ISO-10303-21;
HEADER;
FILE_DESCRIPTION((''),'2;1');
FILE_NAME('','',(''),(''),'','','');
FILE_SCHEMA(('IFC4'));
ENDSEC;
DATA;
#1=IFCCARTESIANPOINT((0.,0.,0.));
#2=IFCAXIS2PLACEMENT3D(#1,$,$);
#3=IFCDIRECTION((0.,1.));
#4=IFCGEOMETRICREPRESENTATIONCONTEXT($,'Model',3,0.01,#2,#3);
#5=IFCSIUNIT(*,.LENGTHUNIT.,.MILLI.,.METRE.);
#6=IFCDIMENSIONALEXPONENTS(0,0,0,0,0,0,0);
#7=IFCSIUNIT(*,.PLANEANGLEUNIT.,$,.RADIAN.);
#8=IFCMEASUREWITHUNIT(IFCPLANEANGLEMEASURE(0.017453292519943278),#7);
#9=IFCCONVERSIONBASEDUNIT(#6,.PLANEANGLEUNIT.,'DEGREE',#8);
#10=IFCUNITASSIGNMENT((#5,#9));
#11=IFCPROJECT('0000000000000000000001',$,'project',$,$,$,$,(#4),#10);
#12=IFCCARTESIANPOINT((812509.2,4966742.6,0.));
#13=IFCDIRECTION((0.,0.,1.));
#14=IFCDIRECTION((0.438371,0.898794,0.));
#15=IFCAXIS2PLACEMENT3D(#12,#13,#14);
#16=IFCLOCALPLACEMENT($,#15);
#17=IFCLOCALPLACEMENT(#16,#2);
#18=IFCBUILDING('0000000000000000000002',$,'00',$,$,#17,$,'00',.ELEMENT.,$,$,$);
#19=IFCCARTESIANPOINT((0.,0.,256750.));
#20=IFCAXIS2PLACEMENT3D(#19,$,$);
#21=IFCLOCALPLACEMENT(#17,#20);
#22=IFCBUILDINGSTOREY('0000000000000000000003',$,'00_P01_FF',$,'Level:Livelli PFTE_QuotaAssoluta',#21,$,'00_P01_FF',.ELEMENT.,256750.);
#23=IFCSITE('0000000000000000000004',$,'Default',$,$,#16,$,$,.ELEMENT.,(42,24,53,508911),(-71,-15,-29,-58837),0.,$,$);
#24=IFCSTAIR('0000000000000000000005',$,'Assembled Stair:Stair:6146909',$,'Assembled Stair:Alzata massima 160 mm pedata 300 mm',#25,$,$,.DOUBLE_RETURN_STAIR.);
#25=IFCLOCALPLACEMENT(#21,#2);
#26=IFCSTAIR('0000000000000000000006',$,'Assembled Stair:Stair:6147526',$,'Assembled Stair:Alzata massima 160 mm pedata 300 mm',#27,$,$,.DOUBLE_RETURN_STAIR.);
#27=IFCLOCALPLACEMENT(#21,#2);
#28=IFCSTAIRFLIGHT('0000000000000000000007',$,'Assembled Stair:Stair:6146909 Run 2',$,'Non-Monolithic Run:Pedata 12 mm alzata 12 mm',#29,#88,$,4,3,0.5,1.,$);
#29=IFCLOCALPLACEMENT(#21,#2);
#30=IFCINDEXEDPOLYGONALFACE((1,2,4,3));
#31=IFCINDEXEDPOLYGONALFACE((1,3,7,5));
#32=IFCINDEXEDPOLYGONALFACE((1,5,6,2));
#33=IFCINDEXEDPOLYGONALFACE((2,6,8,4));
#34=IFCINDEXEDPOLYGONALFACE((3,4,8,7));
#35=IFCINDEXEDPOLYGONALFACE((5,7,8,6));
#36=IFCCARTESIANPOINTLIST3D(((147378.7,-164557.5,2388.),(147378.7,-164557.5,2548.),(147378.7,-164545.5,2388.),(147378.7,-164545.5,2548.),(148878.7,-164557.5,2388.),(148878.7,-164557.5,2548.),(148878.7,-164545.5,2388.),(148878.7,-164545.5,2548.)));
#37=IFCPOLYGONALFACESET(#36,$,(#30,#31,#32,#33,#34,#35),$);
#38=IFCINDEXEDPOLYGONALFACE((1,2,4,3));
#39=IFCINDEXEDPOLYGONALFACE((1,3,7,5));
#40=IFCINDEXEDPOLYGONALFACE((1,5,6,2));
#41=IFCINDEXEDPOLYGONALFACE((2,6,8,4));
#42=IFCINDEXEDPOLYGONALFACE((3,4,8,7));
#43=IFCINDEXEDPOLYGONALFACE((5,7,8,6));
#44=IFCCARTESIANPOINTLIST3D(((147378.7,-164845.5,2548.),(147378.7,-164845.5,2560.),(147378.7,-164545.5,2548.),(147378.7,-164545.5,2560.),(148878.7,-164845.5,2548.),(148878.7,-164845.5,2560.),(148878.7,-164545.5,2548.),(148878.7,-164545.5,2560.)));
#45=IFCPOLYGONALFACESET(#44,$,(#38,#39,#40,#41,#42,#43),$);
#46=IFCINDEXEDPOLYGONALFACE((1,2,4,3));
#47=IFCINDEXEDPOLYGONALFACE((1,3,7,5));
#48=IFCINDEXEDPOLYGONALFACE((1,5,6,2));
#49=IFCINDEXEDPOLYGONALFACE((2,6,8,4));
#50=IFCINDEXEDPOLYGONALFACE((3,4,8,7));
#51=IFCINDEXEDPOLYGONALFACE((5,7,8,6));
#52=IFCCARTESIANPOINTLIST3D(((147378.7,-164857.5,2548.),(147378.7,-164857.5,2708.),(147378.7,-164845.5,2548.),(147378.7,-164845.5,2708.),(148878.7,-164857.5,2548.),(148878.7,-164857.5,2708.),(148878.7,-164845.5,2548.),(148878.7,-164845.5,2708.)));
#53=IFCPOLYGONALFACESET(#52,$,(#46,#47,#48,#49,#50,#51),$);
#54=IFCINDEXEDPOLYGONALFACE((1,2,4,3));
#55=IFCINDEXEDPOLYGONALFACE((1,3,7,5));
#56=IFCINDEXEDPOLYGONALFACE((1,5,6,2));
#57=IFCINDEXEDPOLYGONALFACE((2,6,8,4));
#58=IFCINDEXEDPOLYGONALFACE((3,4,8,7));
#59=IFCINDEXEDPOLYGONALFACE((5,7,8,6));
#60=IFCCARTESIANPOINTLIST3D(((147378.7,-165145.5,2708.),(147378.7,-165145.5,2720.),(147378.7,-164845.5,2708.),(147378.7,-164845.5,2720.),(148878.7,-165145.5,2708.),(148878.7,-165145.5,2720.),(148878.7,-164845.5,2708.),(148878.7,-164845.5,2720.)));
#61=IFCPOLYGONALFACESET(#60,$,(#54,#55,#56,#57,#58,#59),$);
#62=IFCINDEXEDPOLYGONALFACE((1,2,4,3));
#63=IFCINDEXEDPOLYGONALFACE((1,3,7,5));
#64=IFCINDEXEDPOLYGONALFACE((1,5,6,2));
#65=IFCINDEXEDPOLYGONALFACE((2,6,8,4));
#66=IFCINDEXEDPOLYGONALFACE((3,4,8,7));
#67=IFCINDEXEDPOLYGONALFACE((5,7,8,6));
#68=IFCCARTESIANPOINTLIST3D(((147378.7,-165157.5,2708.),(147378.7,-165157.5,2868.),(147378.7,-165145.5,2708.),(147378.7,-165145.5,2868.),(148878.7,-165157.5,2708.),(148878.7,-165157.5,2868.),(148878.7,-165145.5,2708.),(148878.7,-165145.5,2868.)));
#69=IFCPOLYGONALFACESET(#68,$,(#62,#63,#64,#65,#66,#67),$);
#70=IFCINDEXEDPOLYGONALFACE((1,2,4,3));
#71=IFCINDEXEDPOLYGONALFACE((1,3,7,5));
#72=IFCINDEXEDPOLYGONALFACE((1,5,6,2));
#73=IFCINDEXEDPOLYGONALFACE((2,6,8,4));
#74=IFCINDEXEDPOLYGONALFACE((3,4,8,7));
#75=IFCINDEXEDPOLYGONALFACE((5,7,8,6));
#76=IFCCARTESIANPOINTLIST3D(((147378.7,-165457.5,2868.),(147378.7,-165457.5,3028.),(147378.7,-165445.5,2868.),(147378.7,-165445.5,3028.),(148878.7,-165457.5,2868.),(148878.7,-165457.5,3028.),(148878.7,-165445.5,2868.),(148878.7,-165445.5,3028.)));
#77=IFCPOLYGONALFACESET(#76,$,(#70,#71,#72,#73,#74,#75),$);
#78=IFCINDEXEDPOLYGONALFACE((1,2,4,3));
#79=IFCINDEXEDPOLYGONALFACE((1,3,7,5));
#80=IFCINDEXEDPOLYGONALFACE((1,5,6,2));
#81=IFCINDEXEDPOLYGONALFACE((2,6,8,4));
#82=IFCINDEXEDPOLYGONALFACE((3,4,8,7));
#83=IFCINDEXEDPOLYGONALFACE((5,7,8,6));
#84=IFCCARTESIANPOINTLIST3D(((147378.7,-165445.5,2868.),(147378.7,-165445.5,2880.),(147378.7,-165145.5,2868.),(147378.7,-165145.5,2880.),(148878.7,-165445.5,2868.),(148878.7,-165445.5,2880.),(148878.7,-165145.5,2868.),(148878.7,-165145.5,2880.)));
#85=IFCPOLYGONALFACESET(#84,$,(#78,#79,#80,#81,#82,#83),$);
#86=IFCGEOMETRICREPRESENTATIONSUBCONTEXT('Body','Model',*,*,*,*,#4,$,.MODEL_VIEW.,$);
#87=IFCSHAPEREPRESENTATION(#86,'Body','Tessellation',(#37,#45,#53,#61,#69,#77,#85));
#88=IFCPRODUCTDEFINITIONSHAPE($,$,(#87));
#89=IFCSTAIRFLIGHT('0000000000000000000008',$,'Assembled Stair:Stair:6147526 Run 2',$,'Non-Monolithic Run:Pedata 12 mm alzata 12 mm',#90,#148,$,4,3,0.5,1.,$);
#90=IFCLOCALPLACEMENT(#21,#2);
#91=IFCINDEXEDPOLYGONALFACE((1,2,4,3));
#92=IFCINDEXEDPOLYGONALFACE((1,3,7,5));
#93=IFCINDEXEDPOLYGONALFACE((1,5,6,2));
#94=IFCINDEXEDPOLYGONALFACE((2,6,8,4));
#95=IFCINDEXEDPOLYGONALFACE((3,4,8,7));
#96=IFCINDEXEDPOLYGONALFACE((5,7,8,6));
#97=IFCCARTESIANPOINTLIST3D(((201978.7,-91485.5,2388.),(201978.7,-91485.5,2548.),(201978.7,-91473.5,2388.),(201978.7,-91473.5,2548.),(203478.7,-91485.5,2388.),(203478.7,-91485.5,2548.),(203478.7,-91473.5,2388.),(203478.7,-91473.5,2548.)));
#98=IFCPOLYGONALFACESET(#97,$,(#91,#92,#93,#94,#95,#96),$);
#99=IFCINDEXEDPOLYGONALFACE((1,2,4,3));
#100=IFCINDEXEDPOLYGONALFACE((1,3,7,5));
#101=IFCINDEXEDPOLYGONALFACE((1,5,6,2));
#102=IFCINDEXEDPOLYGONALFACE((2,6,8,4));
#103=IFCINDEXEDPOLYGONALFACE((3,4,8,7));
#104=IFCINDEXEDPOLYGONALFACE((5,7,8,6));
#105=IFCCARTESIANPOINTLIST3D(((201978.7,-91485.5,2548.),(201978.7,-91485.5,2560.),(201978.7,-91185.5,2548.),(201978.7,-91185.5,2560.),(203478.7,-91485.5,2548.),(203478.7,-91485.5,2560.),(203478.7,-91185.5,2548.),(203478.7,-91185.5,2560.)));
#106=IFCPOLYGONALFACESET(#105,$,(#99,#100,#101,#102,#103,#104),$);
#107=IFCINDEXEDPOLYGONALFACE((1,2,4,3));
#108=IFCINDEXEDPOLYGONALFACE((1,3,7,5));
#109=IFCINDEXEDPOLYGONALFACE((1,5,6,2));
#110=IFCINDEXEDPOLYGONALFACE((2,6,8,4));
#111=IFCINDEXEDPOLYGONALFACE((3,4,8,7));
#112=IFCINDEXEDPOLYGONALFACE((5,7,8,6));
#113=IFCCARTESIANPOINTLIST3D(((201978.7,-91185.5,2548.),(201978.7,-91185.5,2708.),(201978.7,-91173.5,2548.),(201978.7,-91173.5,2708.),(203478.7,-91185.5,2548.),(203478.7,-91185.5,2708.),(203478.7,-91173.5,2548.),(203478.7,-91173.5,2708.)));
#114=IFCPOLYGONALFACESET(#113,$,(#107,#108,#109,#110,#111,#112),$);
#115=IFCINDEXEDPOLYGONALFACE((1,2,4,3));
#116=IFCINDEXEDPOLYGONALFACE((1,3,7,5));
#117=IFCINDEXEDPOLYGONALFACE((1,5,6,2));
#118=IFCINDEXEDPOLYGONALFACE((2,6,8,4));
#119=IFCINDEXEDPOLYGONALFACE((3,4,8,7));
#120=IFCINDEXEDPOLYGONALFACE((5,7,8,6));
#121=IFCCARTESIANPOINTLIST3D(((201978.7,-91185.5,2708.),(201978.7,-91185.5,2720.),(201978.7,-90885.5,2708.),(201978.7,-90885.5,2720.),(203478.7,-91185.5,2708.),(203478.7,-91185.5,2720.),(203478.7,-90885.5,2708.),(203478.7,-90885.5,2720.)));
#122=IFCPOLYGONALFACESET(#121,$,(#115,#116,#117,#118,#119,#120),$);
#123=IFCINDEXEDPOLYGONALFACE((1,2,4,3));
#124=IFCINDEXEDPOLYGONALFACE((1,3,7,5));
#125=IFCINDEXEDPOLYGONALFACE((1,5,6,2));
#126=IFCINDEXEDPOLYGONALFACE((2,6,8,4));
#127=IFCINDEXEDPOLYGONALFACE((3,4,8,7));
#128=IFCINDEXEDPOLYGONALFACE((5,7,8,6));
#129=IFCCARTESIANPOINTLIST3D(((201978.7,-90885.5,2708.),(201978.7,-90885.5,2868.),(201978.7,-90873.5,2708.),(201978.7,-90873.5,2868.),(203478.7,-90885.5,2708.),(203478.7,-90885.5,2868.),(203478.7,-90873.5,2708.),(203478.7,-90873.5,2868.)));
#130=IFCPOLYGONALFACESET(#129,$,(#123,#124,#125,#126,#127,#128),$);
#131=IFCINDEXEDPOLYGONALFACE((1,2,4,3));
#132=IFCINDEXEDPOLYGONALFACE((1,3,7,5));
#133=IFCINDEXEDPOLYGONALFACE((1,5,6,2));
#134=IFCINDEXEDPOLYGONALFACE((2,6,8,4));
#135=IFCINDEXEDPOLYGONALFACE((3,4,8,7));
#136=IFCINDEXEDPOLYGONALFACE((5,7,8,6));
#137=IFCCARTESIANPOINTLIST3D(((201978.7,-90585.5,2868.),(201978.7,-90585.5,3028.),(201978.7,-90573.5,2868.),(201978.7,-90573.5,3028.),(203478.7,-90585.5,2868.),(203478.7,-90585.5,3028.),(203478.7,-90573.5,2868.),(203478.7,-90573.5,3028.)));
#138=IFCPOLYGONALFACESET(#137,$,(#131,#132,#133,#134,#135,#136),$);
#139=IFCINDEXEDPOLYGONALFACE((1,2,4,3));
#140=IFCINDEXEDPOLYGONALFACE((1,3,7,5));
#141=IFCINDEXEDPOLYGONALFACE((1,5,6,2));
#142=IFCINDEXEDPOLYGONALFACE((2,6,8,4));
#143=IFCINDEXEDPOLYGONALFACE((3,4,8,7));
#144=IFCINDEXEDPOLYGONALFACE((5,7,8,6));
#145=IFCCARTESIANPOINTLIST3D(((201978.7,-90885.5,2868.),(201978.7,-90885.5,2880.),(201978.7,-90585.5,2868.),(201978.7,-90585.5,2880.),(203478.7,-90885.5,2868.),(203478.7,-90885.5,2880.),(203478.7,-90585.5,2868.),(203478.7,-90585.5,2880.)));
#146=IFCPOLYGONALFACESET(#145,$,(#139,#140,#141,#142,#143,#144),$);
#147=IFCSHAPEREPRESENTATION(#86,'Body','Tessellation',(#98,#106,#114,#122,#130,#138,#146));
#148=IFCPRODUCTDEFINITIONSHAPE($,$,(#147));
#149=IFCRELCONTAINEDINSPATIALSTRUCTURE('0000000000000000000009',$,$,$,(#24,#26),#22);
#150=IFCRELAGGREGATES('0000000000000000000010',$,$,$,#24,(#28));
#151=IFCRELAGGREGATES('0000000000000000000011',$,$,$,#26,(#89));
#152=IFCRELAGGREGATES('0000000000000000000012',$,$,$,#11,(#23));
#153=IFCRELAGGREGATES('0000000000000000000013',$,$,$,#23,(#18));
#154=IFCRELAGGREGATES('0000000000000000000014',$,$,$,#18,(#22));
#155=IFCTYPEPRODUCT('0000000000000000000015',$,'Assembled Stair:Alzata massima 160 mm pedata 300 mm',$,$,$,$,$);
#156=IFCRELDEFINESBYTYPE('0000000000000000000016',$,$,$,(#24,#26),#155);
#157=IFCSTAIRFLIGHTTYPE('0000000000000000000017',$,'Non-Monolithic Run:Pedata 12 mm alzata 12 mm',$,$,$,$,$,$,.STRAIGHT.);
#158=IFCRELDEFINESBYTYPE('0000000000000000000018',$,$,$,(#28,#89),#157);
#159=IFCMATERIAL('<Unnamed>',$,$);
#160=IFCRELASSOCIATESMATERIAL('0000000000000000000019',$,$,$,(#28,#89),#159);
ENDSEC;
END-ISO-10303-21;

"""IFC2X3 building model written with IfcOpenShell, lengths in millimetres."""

from ifc_helpers import new_model, entity, si_unit, converted_unit, direction, frame, frame_2d, origin, origin_2d_with_axis, place, context, subcontext, project, spatial, rectangle, extrude, material, type_object, element, aggregate, save


model = new_model("IFC2X3")

# Units and contexts
model_context = context("Model", 3, precision=0.01, world=origin(), true_north=direction((0.0, 1.0)))
body_context = subcontext(model_context, "Body", "Model", "MODEL_VIEW")
ifc_project = project(units=[si_unit("LENGTHUNIT", "METRE", prefix="MILLI"), converted_unit("PLANEANGLEUNIT", "DEGREE", entity("IfcPlaneAngleMeasure", 0.017453292519943278), si_unit("PLANEANGLEUNIT", "RADIAN"), dimensions=[0, 0, 0, 0, 0, 0, 0])], contexts=[model_context])

# Site, building, storey
site_placement = place(None, frame((812509.2, 4966742.6, 0.0), z_axis=(0.0, 0.0, 1.0), x_axis=(0.438371, 0.898794, 0.0)))
site = spatial("IfcSite", under=ifc_project, at=site_placement, Name="Default", CompositionType="ELEMENT", RefLatitude=(42, 24, 53, 508911), RefLongitude=(-71, -15, -29, -58837), RefElevation=0.0)
building_placement = place(site_placement, origin())
building = spatial("IfcBuilding", under=site, at=building_placement, Name="00", LongName="00", CompositionType="ELEMENT")
storey_placement = place(building_placement, frame((0.0, 0.0, 256750.0)))
storey = spatial("IfcBuildingStorey", under=building, at=storey_placement, Name="00_P01_FF", ObjectType="Level:Livelli PFTE_QuotaAssoluta", LongName="00_P01_FF", CompositionType="ELEMENT", Elevation=256750.0)

# Stairs
type_product = type_object("IfcTypeProduct", Name="Assembled Stair:Alzata massima 160 mm pedata 300 mm")
ifc_material = material(Name="<Unnamed>")
stair_1_placement = place(storey_placement, origin())
stair_1 = element("IfcStair", 1, at=stair_1_placement, inside=storey, type_object=type_product, Name="Assembled Stair:Stair:6146909", ObjectType="Assembled Stair:Alzata massima 160 mm pedata 300 mm", ShapeType="DOUBLE_RETURN_STAIR")
stair_2_placement = place(storey_placement, origin())
stair_2 = element("IfcStair", 2, at=stair_2_placement, inside=storey, type_object=type_product, Name="Assembled Stair:Stair:6147526", ObjectType="Assembled Stair:Alzata massima 160 mm pedata 300 mm", ShapeType="DOUBLE_RETURN_STAIR")

# Stair flights
stair_flight_type = type_object("IfcStairFlightType", Name="Non-Monolithic Run:Pedata 12 mm alzata 12 mm", PredefinedType="STRAIGHT")
stair_flight_1_placement = place(stair_1_placement, origin())
stair_flight_1 = element("IfcStairFlight", 3, at=stair_flight_1_placement, type_object=stair_flight_type, material=ifc_material, Name="Assembled Stair:Stair:6146909 Run 2", ObjectType="Non-Monolithic Run:Pedata 12 mm alzata 12 mm", NumberOfRiser=4, NumberOfTreads=3, RiserHeight=0.5, TreadLength=1.0, context=body_context, shape_type="SweptSolid", body=[
    extrude(rectangle(XDim=1500.0, YDim=12.0, at=origin_2d_with_axis()), frame((148128.7, -164551.5, 2388.0)), (0.0, 0.0, 1.0), 160.0),
    extrude(rectangle(XDim=300.0, YDim=1500.0, at=origin_2d_with_axis()), frame((148128.7, -164695.5, 2548.0), z_axis=(0.0, 0.0, 1.0), x_axis=(0.0, 1.0, 0.0)), (0.0, 0.0, 1.0), 12.0),
    extrude(rectangle(XDim=1500.0, YDim=12.0, at=origin_2d_with_axis()), frame((148128.7, -164851.5, 2548.0)), (0.0, 0.0, 1.0), 160.0),
    extrude(rectangle(XDim=300.0, YDim=1500.0, at=frame_2d((0.0, 0.0), x_axis=(1.0, 0.0))), frame((148128.7, -164995.5, 2708.0), z_axis=(0.0, 0.0, 1.0), x_axis=(0.0, 1.0, 0.0)), (0.0, 0.0, 1.0), 12.0),
    extrude(rectangle(XDim=1500.0, YDim=12.0, at=origin_2d_with_axis()), frame((148128.7, -165151.5, 2708.0)), (0.0, 0.0, 1.0), 160.0),
    extrude(rectangle(XDim=1500.0, YDim=12.0, at=origin_2d_with_axis()), frame((148128.7, -165451.5, 2868.0)), (0.0, 0.0, 1.0), 160.0),
    extrude(rectangle(XDim=300.0, YDim=1500.0, at=frame_2d((0.0, 0.0), x_axis=(1.0, 0.0))), frame((148128.7, -165295.5, 2868.0), z_axis=(0.0, 0.0, 1.0), x_axis=(0.0, 1.0, 0.0)), (0.0, 0.0, 1.0), 12.0),
])
aggregate(stair_1, [stair_flight_1])
stair_flight_2_placement = place(stair_2_placement, origin())
stair_flight_2 = element("IfcStairFlight", 4, at=stair_flight_2_placement, type_object=stair_flight_type, material=ifc_material, Name="Assembled Stair:Stair:6147526 Run 2", ObjectType="Non-Monolithic Run:Pedata 12 mm alzata 12 mm", NumberOfRiser=4, NumberOfTreads=3, RiserHeight=0.5, TreadLength=1.0, context=body_context, shape_type="SweptSolid", body=[
    extrude(rectangle(XDim=1500.0, YDim=12.0, at=origin_2d_with_axis()), frame((202728.7, -91479.5, 2388.0), z_axis=(0.0, 0.0, 1.0), x_axis=(-1.0, 0.0, 0.0)), (0.0, 0.0, 1.0), 160.0),
    extrude(rectangle(XDim=300.0, YDim=1500.0, at=origin_2d_with_axis()), frame((202728.7, -91335.5, 2548.0), z_axis=(0.0, 0.0, 1.0), x_axis=(0.0, -1.0, 0.0)), (0.0, 0.0, 1.0), 12.0),
    extrude(rectangle(XDim=1500.0, YDim=12.0, at=origin_2d_with_axis()), frame((202728.7, -91179.5, 2548.0), z_axis=(0.0, 0.0, 1.0), x_axis=(-1.0, 0.0, 0.0)), (0.0, 0.0, 1.0), 160.0),
    extrude(rectangle(XDim=300.0, YDim=1500.0, at=frame_2d((0.0, 0.0), x_axis=(1.0, 0.0))), frame((202728.7, -91035.5, 2708.0), z_axis=(0.0, 0.0, 1.0), x_axis=(0.0, -1.0, 0.0)), (0.0, 0.0, 1.0), 12.0),
    extrude(rectangle(XDim=1500.0, YDim=12.0, at=origin_2d_with_axis()), frame((202728.7, -90879.5, 2708.0), z_axis=(0.0, 0.0, 1.0), x_axis=(-1.0, 0.0, 0.0)), (0.0, 0.0, 1.0), 160.0),
    extrude(rectangle(XDim=1500.0, YDim=12.0, at=origin_2d_with_axis()), frame((202728.7, -90579.5, 2868.0), z_axis=(0.0, 0.0, 1.0), x_axis=(-1.0, 0.0, 0.0)), (0.0, 0.0, 1.0), 160.0),
    extrude(rectangle(XDim=300.0, YDim=1500.0, at=frame_2d((0.0, 0.0), x_axis=(1.0, 0.0))), frame((202728.7, -90735.5, 2868.0), z_axis=(0.0, 0.0, 1.0), x_axis=(0.0, -1.0, 0.0)), (0.0, 0.0, 1.0), 12.0),
])
aggregate(stair_2, [stair_flight_2])

save(model, "model.ifc")
